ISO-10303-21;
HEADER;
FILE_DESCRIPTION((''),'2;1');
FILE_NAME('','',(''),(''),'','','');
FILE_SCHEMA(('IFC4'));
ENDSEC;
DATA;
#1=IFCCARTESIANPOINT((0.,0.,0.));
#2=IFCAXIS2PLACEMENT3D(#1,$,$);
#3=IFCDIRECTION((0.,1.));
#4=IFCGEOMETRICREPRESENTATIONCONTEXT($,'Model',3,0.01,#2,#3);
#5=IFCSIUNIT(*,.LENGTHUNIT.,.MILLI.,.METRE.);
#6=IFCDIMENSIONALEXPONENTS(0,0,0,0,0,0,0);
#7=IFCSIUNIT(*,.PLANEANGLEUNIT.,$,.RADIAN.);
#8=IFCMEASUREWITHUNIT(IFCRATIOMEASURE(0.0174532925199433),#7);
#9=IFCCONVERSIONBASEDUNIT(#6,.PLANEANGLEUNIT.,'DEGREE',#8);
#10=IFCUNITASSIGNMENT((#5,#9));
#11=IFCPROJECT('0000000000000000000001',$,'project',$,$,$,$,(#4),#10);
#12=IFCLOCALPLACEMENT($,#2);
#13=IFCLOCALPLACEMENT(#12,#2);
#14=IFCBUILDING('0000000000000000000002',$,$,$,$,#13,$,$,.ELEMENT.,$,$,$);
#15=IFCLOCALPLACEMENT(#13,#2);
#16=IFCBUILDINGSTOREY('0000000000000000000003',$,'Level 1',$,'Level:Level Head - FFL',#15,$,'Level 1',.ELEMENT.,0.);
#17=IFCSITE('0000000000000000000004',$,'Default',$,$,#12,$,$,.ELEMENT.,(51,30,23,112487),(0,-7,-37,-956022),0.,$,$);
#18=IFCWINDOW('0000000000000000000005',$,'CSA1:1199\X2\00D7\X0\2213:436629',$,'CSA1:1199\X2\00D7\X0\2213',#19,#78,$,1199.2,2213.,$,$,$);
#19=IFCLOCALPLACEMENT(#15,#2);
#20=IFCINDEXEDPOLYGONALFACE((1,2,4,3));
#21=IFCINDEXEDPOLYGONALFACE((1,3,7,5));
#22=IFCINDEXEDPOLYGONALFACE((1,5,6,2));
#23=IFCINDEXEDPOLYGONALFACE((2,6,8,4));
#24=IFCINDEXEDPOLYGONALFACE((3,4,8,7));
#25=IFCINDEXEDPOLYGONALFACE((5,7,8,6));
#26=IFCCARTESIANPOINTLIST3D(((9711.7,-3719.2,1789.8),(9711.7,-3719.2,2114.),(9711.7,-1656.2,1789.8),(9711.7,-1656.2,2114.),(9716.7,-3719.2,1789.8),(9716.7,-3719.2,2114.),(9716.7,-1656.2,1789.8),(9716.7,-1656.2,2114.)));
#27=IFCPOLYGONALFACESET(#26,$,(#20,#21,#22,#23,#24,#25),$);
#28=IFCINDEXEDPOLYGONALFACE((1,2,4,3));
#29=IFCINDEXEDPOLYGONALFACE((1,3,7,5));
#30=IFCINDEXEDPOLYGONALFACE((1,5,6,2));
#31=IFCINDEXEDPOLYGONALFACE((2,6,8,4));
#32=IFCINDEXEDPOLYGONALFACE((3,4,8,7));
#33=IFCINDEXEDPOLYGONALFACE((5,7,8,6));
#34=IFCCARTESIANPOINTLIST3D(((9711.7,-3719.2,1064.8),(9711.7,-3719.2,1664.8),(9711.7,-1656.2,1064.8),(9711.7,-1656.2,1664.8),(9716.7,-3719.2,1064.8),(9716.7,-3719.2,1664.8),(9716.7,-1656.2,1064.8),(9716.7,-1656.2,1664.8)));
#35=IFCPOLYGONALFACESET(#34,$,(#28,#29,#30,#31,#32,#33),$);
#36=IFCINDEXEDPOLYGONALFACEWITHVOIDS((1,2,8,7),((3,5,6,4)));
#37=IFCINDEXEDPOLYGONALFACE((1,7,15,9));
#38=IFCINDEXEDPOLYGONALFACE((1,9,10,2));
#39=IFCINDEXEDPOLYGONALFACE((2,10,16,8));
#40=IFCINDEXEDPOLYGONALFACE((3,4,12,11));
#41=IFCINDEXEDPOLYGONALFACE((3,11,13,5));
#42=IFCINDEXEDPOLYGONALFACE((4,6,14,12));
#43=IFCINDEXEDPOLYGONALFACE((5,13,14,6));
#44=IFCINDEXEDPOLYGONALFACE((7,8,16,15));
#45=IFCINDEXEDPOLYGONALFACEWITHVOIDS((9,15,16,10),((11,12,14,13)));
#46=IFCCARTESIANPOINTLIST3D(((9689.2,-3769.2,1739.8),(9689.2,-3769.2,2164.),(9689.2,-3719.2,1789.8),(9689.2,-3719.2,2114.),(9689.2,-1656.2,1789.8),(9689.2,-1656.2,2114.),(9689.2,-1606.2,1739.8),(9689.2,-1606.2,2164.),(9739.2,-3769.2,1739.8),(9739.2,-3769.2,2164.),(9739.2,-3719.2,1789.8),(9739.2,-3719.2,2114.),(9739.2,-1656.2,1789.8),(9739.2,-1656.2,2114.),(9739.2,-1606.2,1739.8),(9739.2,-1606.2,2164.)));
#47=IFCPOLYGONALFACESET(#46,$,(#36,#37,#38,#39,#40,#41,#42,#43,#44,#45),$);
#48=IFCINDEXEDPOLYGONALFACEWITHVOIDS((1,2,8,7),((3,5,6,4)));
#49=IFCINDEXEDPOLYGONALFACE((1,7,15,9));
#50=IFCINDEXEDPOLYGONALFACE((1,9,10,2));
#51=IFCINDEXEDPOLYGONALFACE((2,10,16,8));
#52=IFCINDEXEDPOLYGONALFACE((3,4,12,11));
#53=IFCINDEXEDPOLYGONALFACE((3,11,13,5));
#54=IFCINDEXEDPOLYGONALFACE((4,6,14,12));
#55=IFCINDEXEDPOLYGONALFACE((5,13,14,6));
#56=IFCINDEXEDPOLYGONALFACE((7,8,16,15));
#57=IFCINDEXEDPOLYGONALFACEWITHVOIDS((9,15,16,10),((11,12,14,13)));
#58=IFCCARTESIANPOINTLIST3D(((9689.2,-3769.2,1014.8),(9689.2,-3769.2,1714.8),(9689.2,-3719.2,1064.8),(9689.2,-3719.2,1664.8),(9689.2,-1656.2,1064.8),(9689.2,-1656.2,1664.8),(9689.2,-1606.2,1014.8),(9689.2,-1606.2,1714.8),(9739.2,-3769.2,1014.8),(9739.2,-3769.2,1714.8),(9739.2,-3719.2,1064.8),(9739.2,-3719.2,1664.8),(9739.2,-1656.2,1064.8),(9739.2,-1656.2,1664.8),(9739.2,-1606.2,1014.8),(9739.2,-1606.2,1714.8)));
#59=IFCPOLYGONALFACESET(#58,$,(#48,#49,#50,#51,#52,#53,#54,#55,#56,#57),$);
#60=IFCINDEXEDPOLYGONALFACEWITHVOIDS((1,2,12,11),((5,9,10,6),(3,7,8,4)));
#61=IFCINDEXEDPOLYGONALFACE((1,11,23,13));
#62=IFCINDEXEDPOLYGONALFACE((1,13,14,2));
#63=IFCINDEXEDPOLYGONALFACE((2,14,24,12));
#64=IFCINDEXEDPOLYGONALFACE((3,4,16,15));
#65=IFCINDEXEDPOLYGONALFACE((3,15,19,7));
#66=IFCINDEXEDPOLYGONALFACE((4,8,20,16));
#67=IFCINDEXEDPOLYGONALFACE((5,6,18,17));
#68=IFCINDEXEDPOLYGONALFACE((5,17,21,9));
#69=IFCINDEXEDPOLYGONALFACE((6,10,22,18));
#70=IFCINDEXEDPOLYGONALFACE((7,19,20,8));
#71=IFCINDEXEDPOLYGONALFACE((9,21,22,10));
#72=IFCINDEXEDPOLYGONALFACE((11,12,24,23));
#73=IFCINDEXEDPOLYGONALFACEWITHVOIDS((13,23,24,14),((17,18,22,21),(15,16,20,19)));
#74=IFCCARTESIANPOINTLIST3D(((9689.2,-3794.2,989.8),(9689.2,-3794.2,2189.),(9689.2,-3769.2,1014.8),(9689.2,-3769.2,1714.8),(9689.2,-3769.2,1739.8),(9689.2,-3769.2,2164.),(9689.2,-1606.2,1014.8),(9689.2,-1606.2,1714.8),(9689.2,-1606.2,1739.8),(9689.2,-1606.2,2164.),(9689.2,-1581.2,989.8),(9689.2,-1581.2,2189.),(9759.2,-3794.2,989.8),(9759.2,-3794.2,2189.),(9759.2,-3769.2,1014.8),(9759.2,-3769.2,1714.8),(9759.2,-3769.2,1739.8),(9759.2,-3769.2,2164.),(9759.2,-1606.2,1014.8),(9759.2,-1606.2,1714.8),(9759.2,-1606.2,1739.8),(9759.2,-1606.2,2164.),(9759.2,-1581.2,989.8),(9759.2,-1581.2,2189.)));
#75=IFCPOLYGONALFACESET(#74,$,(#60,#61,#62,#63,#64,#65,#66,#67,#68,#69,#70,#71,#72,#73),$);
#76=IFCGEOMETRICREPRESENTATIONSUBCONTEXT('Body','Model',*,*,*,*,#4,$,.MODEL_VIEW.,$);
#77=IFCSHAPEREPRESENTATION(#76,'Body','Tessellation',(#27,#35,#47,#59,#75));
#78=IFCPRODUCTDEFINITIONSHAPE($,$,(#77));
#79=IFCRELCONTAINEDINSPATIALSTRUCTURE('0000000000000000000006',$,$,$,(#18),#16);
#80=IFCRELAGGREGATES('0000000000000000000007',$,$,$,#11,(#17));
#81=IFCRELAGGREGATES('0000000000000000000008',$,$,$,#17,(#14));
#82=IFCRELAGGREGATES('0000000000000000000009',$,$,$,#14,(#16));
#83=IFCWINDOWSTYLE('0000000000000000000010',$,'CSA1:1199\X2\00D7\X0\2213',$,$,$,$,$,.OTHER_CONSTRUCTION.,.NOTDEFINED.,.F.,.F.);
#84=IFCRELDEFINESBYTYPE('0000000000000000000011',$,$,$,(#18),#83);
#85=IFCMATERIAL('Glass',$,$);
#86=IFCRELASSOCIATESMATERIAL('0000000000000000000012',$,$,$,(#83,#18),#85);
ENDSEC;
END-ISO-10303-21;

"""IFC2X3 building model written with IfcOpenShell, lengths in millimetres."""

from ifc_helpers import new_model, entity, si_unit, converted_unit, direction, frame, frame_2d, origin, place, context, subcontext, project, spatial, polyline, rectangle, outline, extrude, source, transform, mapped, material, type_object, type_shapes, element, save


model = new_model("IFC2X3")

# Units and contexts
model_context = context("Model", 3, precision=0.01, world=origin(), true_north=direction((0.0, 1.0)))
body_context = subcontext(model_context, "Body", "Model", "MODEL_VIEW")
ifc_project = project(units=[si_unit("LENGTHUNIT", "METRE", prefix="MILLI"), converted_unit("PLANEANGLEUNIT", "DEGREE", entity("IfcRatioMeasure", 0.0174532925199433), si_unit("PLANEANGLEUNIT", "RADIAN"), dimensions=[0, 0, 0, 0, 0, 0, 0])], contexts=[model_context])

# Site, building, storey
site_placement = place(None, origin())
site = spatial("IfcSite", under=ifc_project, at=site_placement, Name="Default", CompositionType="ELEMENT", RefLatitude=(51, 30, 23, 112487), RefLongitude=(0, -7, -37, -956022), RefElevation=0.0)
building_placement = place(site_placement, origin())
building = spatial("IfcBuilding", under=site, at=building_placement, CompositionType="ELEMENT")
storey_placement = place(building_placement, origin())
storey = spatial("IfcBuildingStorey", under=building, at=storey_placement, Name="Level 1", ObjectType="Level:Level Head - FFL", LongName="Level 1", CompositionType="ELEMENT", Elevation=0.0)

# Window
ifc_material_1 = material(Name="Glass")
window_style_1 = type_object("IfcWindowStyle", Name="CSA1:1199×2213", ConstructionType="OTHER_CONSTRUCTION", OperationType="NOTDEFINED", ParameterTakesPrecedence=False, Sizeable=False, material=ifc_material_1)
shared_shape_1 = source(origin(), body_context, "Body", "SweptSolid", [
    extrude(rectangle(XDim=5.0, YDim=2063.0, at=frame_2d((0.0, 0.0), x_axis=(1.0, 0.0))), frame((1106.5, 45.0, 800.0), z_axis=(0.0, 0.0, 1.0), x_axis=(0.0, 1.0, 0.0)), (0.0, 0.0, 1.0), 324.2),
    extrude(rectangle(XDim=5.0, YDim=2063.0, at=frame_2d((0.0, 0.0), x_axis=(1.0, 0.0))), frame((1106.5, 45.0, 75.0), z_axis=(0.0, 0.0, 1.0), x_axis=(0.0, 1.0, 0.0)), (0.0, 0.0, 1.0), 600.0),
    extrude(outline(polyline([(-1081.5, -212.1), (1081.5, -212.1), (1081.5, 212.1), (-1081.5, 212.1), (-1081.5, -212.1)]), holes=[polyline([(-1031.5, -162.1), (-1031.5, 162.1), (1031.5, 162.1), (1031.5, -162.1), (-1031.5, -162.1)])]), frame((1106.5, 20.0, 962.1), z_axis=(0.0, 1.0, 0.0), x_axis=(1.0, 0.0, 0.0)), (0.0, 0.0, 1.0), 50.0),
    extrude(outline(polyline([(-1081.5, -350.0), (1081.5, -350.0), (1081.5, 350.0), (-1081.5, 350.0), (-1081.5, -350.0)]), holes=[polyline([(-1031.5, -300.0), (-1031.5, 300.0), (1031.5, 300.0), (1031.5, -300.0), (-1031.5, -300.0)])]), frame((1106.5, 20.0, 375.0), z_axis=(0.0, 1.0, 0.0), x_axis=(1.0, 0.0, 0.0)), (0.0, 0.0, 1.0), 50.0),
    extrude(outline(polyline([(-1106.5, -599.6), (1106.5, -599.6), (1106.5, 599.6), (-1106.5, 599.6), (-1106.5, -599.6)]), holes=[polyline([(-1081.5, -574.6), (-1081.5, -150.4), (1081.5, -150.4), (1081.5, -574.6), (-1081.5, -574.6)]), polyline([(-1081.5, -125.4), (-1081.5, 574.6), (1081.5, 574.6), (1081.5, -125.4), (-1081.5, -125.4)])]), frame((1106.5, 0.0, 599.6), z_axis=(0.0, 1.0, 0.0), x_axis=(1.0, 0.0, 0.0)), (0.0, 0.0, 1.0), 70.0),
])
type_shapes(window_style_1, [shared_shape_1])
window_1_placement = place(storey_placement, frame((9759.2, -3794.2, 989.8), z_axis=(0.0, 0.0, 1.0), x_axis=(0.0, 1.0, 0.0)))
element("IfcWindow", 1, at=window_1_placement, inside=storey, type_object=window_style_1, material=ifc_material_1, Name="CSA1:1199×2213:436629", ObjectType="CSA1:1199×2213", OverallHeight=1199.2, OverallWidth=2213.0, context=body_context, shape_type="MappedRepresentation", body=[
    mapped(shared_shape_1, transform((0.0, 0.0, 0.0), scale=1.0)),
])

save(model, "model.ifc")
